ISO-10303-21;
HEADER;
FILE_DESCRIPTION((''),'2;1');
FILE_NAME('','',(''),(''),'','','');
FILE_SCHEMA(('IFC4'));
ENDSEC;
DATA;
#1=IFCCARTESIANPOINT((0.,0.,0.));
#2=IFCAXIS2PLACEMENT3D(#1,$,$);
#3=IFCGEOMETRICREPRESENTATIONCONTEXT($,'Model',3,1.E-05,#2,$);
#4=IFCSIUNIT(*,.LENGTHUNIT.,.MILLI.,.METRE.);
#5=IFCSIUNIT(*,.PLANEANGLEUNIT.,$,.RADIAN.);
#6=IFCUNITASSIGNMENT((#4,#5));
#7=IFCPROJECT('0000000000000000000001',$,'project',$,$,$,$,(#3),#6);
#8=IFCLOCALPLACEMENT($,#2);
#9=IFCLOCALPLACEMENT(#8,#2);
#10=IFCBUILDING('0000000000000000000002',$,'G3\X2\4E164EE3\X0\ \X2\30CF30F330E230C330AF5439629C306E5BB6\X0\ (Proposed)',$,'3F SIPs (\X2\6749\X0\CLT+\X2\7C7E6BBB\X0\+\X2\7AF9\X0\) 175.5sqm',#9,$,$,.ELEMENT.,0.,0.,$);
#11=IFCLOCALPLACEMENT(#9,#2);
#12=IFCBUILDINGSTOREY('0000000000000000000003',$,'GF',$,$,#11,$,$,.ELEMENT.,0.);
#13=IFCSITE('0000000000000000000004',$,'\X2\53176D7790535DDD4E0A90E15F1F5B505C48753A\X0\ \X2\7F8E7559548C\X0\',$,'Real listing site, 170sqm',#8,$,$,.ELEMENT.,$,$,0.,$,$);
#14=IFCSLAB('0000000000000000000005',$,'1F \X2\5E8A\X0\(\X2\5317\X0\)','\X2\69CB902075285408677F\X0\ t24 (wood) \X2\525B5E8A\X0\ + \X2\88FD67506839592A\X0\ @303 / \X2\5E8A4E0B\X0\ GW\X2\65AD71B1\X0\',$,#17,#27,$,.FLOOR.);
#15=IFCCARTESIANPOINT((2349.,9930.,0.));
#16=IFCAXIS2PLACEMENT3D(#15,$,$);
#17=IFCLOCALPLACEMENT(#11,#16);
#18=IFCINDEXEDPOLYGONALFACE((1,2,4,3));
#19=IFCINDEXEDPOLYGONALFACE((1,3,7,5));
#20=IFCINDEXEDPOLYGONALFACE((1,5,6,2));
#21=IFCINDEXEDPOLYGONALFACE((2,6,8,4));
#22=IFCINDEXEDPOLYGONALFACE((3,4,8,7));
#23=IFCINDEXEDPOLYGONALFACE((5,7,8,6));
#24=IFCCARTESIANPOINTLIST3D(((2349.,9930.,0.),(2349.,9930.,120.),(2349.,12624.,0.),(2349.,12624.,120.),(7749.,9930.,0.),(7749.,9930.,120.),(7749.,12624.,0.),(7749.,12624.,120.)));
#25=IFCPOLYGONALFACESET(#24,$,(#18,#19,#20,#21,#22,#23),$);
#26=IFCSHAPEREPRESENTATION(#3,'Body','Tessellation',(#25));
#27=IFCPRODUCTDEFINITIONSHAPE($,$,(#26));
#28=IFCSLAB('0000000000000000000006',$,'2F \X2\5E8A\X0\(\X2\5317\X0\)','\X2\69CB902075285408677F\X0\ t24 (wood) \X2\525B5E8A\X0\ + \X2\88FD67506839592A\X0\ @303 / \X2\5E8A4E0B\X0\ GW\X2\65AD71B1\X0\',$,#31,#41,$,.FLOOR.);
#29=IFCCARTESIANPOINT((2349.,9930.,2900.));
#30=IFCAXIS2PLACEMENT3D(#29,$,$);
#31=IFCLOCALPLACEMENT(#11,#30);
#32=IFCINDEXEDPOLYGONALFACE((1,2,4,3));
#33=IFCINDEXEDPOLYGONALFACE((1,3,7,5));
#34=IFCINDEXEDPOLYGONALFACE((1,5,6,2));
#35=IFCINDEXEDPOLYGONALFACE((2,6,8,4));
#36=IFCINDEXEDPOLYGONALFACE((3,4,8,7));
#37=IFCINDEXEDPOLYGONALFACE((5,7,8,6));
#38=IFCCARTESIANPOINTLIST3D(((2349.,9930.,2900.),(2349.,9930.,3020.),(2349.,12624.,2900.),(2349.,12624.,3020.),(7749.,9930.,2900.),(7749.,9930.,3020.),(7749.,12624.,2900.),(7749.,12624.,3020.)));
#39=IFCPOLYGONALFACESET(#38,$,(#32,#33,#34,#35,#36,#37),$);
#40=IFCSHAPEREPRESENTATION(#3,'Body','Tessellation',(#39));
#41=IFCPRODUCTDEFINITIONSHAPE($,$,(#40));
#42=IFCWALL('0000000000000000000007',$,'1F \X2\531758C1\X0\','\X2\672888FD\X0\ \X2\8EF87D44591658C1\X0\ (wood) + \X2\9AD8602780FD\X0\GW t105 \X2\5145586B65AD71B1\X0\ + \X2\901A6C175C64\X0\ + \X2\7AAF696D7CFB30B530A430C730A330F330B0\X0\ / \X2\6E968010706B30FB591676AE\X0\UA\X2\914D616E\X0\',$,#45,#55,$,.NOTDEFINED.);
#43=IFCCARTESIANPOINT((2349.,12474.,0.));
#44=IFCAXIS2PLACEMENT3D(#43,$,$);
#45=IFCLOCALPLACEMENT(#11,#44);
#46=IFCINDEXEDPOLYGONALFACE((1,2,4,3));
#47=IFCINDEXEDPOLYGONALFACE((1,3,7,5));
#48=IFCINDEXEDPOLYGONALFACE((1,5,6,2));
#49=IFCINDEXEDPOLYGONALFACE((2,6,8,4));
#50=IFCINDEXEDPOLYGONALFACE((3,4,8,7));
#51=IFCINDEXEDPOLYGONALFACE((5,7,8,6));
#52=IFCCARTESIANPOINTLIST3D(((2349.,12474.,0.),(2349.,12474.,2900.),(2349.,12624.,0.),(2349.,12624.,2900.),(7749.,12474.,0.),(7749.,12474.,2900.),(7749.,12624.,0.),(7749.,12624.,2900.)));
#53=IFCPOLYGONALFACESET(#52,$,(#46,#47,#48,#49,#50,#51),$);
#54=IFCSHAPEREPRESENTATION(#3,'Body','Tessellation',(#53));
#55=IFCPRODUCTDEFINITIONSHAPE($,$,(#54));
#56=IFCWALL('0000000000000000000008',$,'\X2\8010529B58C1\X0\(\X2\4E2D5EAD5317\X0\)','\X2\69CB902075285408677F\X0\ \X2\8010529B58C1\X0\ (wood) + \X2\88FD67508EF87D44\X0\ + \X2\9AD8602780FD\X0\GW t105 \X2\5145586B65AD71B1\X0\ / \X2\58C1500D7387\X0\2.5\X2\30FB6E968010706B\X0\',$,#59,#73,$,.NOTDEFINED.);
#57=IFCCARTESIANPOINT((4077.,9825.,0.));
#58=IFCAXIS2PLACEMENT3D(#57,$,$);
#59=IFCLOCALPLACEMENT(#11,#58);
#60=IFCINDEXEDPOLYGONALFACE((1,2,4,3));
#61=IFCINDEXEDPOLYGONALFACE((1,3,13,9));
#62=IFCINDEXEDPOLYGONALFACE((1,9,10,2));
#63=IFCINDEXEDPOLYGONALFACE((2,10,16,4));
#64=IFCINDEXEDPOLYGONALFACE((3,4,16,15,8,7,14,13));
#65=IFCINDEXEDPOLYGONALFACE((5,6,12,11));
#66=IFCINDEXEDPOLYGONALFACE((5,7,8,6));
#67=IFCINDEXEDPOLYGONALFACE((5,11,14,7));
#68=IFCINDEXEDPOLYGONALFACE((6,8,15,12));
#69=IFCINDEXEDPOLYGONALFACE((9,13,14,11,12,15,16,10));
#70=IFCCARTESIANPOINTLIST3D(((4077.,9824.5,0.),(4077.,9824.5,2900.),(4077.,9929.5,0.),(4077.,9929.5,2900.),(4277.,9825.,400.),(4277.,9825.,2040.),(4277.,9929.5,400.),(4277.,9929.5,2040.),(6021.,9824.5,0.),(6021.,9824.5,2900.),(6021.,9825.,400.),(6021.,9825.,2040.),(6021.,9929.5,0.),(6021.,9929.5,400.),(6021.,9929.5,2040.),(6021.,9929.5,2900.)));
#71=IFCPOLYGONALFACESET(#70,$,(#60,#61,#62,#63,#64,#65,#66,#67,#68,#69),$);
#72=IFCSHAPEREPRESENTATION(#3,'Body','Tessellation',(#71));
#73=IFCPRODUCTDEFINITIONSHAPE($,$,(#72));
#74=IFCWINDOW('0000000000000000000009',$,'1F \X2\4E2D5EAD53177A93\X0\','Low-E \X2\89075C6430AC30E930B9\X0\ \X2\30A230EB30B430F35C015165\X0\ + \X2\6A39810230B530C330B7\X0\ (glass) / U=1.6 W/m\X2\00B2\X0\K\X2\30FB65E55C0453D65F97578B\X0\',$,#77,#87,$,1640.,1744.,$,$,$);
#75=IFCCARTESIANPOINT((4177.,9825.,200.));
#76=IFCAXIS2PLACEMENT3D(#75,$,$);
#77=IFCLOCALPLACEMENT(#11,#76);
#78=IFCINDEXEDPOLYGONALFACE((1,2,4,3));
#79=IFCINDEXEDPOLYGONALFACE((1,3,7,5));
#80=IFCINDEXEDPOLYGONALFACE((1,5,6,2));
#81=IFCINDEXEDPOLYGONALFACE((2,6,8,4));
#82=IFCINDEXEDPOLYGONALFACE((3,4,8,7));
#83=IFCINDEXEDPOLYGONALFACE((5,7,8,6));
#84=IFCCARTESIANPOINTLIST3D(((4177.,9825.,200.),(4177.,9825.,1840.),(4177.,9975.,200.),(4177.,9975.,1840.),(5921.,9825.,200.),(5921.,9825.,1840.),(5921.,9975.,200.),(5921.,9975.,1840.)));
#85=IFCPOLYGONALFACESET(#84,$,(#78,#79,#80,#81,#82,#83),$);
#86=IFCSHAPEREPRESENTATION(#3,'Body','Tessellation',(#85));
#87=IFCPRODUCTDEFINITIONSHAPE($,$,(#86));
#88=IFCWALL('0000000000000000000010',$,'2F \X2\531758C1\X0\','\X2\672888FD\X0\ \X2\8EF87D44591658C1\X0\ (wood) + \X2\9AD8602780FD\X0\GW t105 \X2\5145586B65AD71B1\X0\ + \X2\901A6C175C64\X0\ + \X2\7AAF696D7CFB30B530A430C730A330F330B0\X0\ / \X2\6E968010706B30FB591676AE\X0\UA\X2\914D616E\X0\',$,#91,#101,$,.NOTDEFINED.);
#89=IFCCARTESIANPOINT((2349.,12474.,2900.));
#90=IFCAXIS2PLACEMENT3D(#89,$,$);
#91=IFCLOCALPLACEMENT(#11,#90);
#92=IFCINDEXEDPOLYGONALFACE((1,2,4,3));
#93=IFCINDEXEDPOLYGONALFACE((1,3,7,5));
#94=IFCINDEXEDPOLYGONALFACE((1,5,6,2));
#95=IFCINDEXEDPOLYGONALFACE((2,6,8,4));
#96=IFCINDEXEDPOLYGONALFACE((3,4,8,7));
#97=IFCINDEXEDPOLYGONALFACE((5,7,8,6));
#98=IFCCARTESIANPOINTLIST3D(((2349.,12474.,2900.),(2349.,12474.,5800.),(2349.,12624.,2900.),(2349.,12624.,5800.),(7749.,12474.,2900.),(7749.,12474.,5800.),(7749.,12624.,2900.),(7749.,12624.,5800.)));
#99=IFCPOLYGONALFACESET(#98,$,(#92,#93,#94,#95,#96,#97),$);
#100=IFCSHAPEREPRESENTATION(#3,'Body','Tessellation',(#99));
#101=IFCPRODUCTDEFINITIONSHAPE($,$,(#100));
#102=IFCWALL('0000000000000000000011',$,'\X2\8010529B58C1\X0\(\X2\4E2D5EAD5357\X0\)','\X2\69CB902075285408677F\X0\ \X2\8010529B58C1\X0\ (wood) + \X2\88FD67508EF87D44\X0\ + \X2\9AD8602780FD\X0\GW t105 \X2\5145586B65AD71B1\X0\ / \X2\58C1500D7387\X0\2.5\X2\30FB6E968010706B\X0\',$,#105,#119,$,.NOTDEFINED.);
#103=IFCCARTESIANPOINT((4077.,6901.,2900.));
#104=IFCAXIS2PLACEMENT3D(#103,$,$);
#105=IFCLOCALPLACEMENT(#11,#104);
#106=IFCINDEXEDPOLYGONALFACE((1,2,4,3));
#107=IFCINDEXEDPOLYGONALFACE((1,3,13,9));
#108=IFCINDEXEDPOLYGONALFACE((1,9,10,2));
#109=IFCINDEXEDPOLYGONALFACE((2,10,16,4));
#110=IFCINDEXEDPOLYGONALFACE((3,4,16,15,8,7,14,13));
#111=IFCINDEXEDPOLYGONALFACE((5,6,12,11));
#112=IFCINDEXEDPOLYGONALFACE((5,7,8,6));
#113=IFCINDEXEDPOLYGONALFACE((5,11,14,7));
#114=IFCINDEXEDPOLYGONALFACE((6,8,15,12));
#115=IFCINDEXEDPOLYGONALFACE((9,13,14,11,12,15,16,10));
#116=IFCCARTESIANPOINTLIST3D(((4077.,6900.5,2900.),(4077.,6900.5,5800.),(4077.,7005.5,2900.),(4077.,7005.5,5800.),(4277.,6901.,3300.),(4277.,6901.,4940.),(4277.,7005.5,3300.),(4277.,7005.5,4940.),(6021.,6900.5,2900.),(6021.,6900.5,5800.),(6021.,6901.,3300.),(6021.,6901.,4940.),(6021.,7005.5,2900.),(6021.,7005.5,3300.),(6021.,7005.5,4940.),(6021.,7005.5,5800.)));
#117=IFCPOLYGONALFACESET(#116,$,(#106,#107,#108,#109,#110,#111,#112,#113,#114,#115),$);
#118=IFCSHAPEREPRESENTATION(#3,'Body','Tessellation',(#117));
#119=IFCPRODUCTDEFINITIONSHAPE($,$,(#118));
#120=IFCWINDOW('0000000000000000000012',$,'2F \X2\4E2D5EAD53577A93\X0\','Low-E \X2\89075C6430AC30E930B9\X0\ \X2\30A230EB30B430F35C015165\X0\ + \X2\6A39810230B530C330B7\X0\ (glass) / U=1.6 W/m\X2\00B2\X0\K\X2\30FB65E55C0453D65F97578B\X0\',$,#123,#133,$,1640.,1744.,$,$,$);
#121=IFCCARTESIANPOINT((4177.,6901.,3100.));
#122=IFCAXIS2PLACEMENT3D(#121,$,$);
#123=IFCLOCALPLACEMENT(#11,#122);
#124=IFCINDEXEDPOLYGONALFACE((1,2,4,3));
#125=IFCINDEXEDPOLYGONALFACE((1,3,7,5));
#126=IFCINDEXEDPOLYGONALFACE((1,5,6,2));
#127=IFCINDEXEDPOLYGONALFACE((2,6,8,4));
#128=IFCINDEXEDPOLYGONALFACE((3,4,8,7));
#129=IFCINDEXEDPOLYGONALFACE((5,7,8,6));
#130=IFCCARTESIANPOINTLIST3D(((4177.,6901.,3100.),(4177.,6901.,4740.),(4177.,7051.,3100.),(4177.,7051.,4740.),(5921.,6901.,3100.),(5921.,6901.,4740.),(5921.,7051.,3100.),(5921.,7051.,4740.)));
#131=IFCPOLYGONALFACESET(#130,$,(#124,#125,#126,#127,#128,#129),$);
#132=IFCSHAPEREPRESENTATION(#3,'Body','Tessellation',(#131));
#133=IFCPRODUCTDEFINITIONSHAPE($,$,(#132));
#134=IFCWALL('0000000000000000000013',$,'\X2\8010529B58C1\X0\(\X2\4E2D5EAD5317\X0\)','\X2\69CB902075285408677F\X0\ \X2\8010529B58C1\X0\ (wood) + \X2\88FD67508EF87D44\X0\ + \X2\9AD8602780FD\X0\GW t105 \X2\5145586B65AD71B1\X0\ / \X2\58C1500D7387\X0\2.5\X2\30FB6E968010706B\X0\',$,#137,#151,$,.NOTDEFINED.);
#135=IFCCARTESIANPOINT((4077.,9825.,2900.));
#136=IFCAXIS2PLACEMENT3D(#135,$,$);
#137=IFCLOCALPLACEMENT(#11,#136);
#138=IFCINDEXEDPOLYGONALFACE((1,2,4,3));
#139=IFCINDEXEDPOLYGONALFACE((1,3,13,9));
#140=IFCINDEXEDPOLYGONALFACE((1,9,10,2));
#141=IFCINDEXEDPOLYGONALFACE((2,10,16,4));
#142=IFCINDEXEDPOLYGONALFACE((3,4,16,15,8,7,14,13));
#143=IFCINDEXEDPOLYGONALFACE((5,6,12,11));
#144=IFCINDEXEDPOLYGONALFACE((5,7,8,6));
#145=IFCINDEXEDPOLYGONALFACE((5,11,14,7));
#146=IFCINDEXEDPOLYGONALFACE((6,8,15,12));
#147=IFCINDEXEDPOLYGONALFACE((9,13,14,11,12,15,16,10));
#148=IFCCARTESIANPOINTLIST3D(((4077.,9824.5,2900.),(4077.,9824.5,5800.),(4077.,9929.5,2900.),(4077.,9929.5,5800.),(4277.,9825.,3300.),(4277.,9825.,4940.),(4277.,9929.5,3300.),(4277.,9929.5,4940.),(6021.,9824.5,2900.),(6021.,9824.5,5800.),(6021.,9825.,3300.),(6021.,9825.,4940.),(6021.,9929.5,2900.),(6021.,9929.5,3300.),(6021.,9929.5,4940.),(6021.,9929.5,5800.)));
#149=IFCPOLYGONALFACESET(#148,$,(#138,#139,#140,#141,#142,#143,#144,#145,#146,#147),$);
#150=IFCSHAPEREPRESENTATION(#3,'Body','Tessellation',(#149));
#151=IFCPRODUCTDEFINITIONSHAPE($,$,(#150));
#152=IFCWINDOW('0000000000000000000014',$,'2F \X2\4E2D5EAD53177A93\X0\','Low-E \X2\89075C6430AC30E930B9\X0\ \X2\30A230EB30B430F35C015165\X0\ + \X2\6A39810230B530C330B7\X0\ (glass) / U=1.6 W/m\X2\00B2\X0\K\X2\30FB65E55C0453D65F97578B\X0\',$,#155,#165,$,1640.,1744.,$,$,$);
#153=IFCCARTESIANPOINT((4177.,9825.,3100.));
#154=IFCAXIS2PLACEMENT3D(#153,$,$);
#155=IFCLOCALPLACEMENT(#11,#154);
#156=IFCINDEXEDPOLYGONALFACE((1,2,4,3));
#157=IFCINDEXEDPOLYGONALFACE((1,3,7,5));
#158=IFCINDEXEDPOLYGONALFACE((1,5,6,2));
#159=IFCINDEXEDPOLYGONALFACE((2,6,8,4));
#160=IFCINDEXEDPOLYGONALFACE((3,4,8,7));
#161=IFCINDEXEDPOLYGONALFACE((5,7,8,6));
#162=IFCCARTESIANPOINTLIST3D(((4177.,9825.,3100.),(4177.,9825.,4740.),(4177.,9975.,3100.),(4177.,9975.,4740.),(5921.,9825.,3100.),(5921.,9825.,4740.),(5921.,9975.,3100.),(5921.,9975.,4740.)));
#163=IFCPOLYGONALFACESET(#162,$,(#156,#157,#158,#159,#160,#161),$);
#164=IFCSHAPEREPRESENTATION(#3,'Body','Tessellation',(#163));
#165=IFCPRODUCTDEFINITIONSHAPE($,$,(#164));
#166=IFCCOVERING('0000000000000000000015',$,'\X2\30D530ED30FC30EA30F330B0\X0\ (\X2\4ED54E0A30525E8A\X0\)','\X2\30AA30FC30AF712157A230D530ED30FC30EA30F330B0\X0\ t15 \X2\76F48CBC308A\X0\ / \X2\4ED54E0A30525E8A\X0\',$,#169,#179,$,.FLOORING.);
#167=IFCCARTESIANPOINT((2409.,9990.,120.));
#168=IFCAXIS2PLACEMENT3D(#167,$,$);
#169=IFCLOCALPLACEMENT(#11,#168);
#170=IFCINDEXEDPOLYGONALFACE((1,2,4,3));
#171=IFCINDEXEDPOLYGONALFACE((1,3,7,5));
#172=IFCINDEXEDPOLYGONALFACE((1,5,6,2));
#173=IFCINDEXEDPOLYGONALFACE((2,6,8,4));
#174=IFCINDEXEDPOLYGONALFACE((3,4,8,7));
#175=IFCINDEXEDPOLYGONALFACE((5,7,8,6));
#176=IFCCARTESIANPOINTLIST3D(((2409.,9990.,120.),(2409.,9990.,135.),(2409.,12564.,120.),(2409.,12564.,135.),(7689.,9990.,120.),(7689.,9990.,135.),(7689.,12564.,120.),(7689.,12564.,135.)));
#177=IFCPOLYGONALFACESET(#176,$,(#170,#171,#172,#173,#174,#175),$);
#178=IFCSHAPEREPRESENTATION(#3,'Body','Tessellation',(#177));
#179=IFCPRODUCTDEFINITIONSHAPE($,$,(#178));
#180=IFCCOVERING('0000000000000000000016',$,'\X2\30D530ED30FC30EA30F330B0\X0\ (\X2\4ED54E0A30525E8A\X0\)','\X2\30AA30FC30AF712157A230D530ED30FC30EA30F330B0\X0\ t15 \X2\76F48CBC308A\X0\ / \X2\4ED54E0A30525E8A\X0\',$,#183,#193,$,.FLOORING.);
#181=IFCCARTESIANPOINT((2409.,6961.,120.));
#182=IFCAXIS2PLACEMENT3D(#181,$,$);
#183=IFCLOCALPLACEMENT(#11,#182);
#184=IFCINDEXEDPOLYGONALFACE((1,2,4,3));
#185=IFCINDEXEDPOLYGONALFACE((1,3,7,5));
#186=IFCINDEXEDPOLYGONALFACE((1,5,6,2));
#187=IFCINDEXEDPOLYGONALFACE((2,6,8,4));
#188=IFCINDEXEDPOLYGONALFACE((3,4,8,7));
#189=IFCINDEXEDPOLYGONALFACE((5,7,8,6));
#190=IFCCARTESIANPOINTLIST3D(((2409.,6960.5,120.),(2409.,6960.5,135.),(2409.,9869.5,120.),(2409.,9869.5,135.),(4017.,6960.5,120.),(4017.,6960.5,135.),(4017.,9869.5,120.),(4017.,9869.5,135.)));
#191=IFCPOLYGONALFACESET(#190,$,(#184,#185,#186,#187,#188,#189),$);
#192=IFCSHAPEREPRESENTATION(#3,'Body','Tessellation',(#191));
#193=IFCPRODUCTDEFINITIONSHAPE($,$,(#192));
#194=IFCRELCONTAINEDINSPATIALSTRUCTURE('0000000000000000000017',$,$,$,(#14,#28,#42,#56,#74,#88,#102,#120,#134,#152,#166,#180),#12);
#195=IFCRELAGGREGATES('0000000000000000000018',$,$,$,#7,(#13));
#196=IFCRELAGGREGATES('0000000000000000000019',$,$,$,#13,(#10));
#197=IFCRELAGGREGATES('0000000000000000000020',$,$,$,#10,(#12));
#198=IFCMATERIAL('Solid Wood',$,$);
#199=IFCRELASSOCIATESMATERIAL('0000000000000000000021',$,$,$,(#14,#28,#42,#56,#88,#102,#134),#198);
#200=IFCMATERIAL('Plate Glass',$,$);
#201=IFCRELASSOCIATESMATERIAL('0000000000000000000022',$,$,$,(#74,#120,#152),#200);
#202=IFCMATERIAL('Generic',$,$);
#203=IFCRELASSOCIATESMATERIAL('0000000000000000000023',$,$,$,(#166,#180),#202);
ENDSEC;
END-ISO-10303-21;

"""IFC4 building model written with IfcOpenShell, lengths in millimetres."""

from ifc_helpers import new_model, si_unit, frame, frame_2d, origin, place, context, project, spatial, rectangle, extrude, material, element, fill, save


model = new_model("IFC4")

# Units and contexts
model_context = context("Model", 3, precision=1e-05, world=origin())
ifc_project = project(units=[si_unit("LENGTHUNIT", "METRE", prefix="MILLI"), si_unit("PLANEANGLEUNIT", "RADIAN")], contexts=[model_context])

# Site, building, storey
site_placement = place(None, origin())
site = spatial("IfcSite", under=ifc_project, at=site_placement, Name="北海道川上郡弟子屈町 美留和", ObjectType="Real listing site, 170sqm", CompositionType="ELEMENT", RefElevation=0.0)
building_placement = place(site_placement, origin())
building = spatial("IfcBuilding", under=site, at=building_placement, Name="G3世代 ハンモック吹抜の家 (Proposed)", ObjectType="3F SIPs (杉CLT+籾殻+竹) 175.5sqm", CompositionType="ELEMENT", ElevationOfRefHeight=0.0, ElevationOfTerrain=0.0)
storey_placement = place(building_placement, origin())
storey = spatial("IfcBuildingStorey", under=building, at=storey_placement, Name="GF", CompositionType="ELEMENT", Elevation=0.0)

# Slabs
ifc_material_1 = material(Name="Solid Wood")
slab_1_placement = place(storey_placement, frame((2349.0, 9930.0, 0.0)))
element("IfcSlab", 1, at=slab_1_placement, inside=storey, material=ifc_material_1, Name="1F 床(北)", Description="構造用合板 t24 (wood) 剛床 + 製材根太 @303 / 床下 GW断熱", PredefinedType="FLOOR", context=model_context, shape_type="SweptSolid", body=[
    extrude(rectangle(XDim=5400.0, YDim=2694.0, at=frame_2d((2700.0, 1347.0))), frame((2349.0, 9930.0, 0.0)), (0.0, 0.0, 1.0), 120.0),
])
slab_2_placement = place(storey_placement, frame((2349.0, 9930.0, 2900.0)))
element("IfcSlab", 2, at=slab_2_placement, inside=storey, material=ifc_material_1, Name="2F 床(北)", Description="構造用合板 t24 (wood) 剛床 + 製材根太 @303 / 床下 GW断熱", PredefinedType="FLOOR", context=model_context, shape_type="SweptSolid", body=[
    extrude(rectangle(XDim=5400.0, YDim=2694.0, at=frame_2d((2700.0, 1347.0))), frame((2349.0, 9930.0, 2900.0)), (0.0, 0.0, 1.0), 120.0),
])

# Wall
wall_1_placement = place(storey_placement, frame((2349.0, 12474.0, 0.0)))
element("IfcWall", 3, at=wall_1_placement, inside=storey, material=ifc_material_1, Name="1F 北壁", Description="木製 軸組外壁 (wood) + 高性能GW t105 充填断熱 + 通気層 + 窯業系サイディング / 準耐火・外皮UA配慮", PredefinedType="NOTDEFINED", context=model_context, shape_type="SweptSolid", body=[
    extrude(rectangle(XDim=5400.0, YDim=150.0, at=frame_2d((2700.0, 75.0))), frame((2349.0, 12474.0, 0.0)), (0.0, 0.0, 1.0), 2900.0),
])

# Wall, opening, window
wall_2_placement = place(storey_placement, frame((4077.0, 9825.0, 0.0)))
wall_2 = element("IfcWall", 4, at=wall_2_placement, inside=storey, material=ifc_material_1, Name="耐力壁(中庭北)", Description="構造用合板 耐力壁 (wood) + 製材軸組 + 高性能GW t105 充填断熱 / 壁倍率2.5・準耐火", PredefinedType="NOTDEFINED", context=model_context, shape_type="SweptSolid", body=[
    extrude(rectangle(XDim=1944.0, YDim=105.0, at=frame_2d((972.0, 52.0))), frame((4077.0, 9825.0, 0.0)), (0.0, 0.0, 1.0), 2900.0),
])
opening_1_placement = place(storey_placement, frame((4177.0, 9825.0, 200.0)))
opening_1 = element("IfcOpeningElement", 5, at=opening_1_placement, cuts=wall_2, PredefinedType="NOTDEFINED", context=model_context, shape_type="SweptSolid", body=[
    extrude(rectangle(XDim=1744.0, YDim=150.0, at=frame_2d((872.0, 75.0))), frame((4177.0, 9825.0, 200.0)), (0.0, 0.0, 1.0), 1640.0),
])
ifc_material_2 = material(Name="Plate Glass")
window_1_placement = place(storey_placement, frame((4177.0, 9825.0, 200.0)))
window_1 = element("IfcWindow", 6, at=window_1_placement, inside=storey, material=ifc_material_2, Name="1F 中庭北窓", Description="Low-E 複層ガラス アルゴン封入 + 樹脂サッシ (glass) / U=1.6 W/m²K・日射取得型", OverallHeight=1640.0, OverallWidth=1744.0, context=model_context, shape_type="SweptSolid", body=[
    extrude(rectangle(XDim=1744.0, YDim=150.0, at=frame_2d((872.0, 75.0))), frame((4177.0, 9825.0, 200.0)), (0.0, 0.0, 1.0), 1640.0),
])
fill(opening_1, window_1)

# Wall
wall_3_placement = place(storey_placement, frame((2349.0, 12474.0, 2900.0)))
element("IfcWall", 7, at=wall_3_placement, inside=storey, material=ifc_material_1, Name="2F 北壁", Description="木製 軸組外壁 (wood) + 高性能GW t105 充填断熱 + 通気層 + 窯業系サイディング / 準耐火・外皮UA配慮", PredefinedType="NOTDEFINED", context=model_context, shape_type="SweptSolid", body=[
    extrude(rectangle(XDim=5400.0, YDim=150.0, at=frame_2d((2700.0, 75.0))), frame((2349.0, 12474.0, 2900.0)), (0.0, 0.0, 1.0), 2900.0),
])

# Walls, openings, windows
wall_4_placement = place(storey_placement, frame((4077.0, 6901.0, 2900.0)))
wall_4 = element("IfcWall", 8, at=wall_4_placement, inside=storey, material=ifc_material_1, Name="耐力壁(中庭南)", Description="構造用合板 耐力壁 (wood) + 製材軸組 + 高性能GW t105 充填断熱 / 壁倍率2.5・準耐火", PredefinedType="NOTDEFINED", context=model_context, shape_type="SweptSolid", body=[
    extrude(rectangle(XDim=1944.0, YDim=105.0, at=frame_2d((972.0, 52.0))), frame((4077.0, 6901.0, 2900.0)), (0.0, 0.0, 1.0), 2900.0),
])
opening_2_placement = place(storey_placement, frame((4177.0, 6901.0, 3100.0)))
opening_2 = element("IfcOpeningElement", 9, at=opening_2_placement, cuts=wall_4, PredefinedType="NOTDEFINED", context=model_context, shape_type="SweptSolid", body=[
    extrude(rectangle(XDim=1744.0, YDim=150.0, at=frame_2d((872.0, 75.0))), frame((4177.0, 6901.0, 3100.0)), (0.0, 0.0, 1.0), 1640.0),
])
window_2_placement = place(storey_placement, frame((4177.0, 6901.0, 3100.0)))
window_2 = element("IfcWindow", 10, at=window_2_placement, inside=storey, material=ifc_material_2, Name="2F 中庭南窓", Description="Low-E 複層ガラス アルゴン封入 + 樹脂サッシ (glass) / U=1.6 W/m²K・日射取得型", OverallHeight=1640.0, OverallWidth=1744.0, context=model_context, shape_type="SweptSolid", body=[
    extrude(rectangle(XDim=1744.0, YDim=150.0, at=frame_2d((872.0, 75.0))), frame((4177.0, 6901.0, 3100.0)), (0.0, 0.0, 1.0), 1640.0),
])
fill(opening_2, window_2)
wall_5_placement = place(storey_placement, frame((4077.0, 9825.0, 2900.0)))
wall_5 = element("IfcWall", 11, at=wall_5_placement, inside=storey, material=ifc_material_1, Name="耐力壁(中庭北)", Description="構造用合板 耐力壁 (wood) + 製材軸組 + 高性能GW t105 充填断熱 / 壁倍率2.5・準耐火", PredefinedType="NOTDEFINED", context=model_context, shape_type="SweptSolid", body=[
    extrude(rectangle(XDim=1944.0, YDim=105.0, at=frame_2d((972.0, 52.0))), frame((4077.0, 9825.0, 2900.0)), (0.0, 0.0, 1.0), 2900.0),
])
opening_3_placement = place(storey_placement, frame((4177.0, 9825.0, 3100.0)))
opening_3 = element("IfcOpeningElement", 12, at=opening_3_placement, cuts=wall_5, PredefinedType="NOTDEFINED", context=model_context, shape_type="SweptSolid", body=[
    extrude(rectangle(XDim=1744.0, YDim=150.0, at=frame_2d((872.0, 75.0))), frame((4177.0, 9825.0, 3100.0)), (0.0, 0.0, 1.0), 1640.0),
])
window_3_placement = place(storey_placement, frame((4177.0, 9825.0, 3100.0)))
window_3 = element("IfcWindow", 13, at=window_3_placement, inside=storey, material=ifc_material_2, Name="2F 中庭北窓", Description="Low-E 複層ガラス アルゴン封入 + 樹脂サッシ (glass) / U=1.6 W/m²K・日射取得型", OverallHeight=1640.0, OverallWidth=1744.0, context=model_context, shape_type="SweptSolid", body=[
    extrude(rectangle(XDim=1744.0, YDim=150.0, at=frame_2d((872.0, 75.0))), frame((4177.0, 9825.0, 3100.0)), (0.0, 0.0, 1.0), 1640.0),
])
fill(opening_3, window_3)

# Coverings
ifc_material_3 = material(Name="Generic")
covering_1_placement = place(storey_placement, frame((2409.0, 9990.0, 120.0)))
element("IfcCovering", 14, at=covering_1_placement, inside=storey, material=ifc_material_3, Name="フローリング (仕上げ床)", Description="オーク無垢フローリング t15 直貼り / 仕上げ床", PredefinedType="FLOORING", context=model_context, shape_type="SweptSolid", body=[
    extrude(rectangle(XDim=5280.0, YDim=2574.0, at=frame_2d((2640.0, 1287.0))), frame((2409.0, 9990.0, 120.0)), (0.0, 0.0, 1.0), 15.0),
])
covering_2_placement = place(storey_placement, frame((2409.0, 6961.0, 120.0)))
element("IfcCovering", 15, at=covering_2_placement, inside=storey, material=ifc_material_3, Name="フローリング (仕上げ床)", Description="オーク無垢フローリング t15 直貼り / 仕上げ床", PredefinedType="FLOORING", context=model_context, shape_type="SweptSolid", body=[
    extrude(rectangle(XDim=1608.0, YDim=2909.0, at=frame_2d((804.0, 1454.0))), frame((2409.0, 6961.0, 120.0)), (0.0, 0.0, 1.0), 15.0),
])

save(model, "model.ifc")
